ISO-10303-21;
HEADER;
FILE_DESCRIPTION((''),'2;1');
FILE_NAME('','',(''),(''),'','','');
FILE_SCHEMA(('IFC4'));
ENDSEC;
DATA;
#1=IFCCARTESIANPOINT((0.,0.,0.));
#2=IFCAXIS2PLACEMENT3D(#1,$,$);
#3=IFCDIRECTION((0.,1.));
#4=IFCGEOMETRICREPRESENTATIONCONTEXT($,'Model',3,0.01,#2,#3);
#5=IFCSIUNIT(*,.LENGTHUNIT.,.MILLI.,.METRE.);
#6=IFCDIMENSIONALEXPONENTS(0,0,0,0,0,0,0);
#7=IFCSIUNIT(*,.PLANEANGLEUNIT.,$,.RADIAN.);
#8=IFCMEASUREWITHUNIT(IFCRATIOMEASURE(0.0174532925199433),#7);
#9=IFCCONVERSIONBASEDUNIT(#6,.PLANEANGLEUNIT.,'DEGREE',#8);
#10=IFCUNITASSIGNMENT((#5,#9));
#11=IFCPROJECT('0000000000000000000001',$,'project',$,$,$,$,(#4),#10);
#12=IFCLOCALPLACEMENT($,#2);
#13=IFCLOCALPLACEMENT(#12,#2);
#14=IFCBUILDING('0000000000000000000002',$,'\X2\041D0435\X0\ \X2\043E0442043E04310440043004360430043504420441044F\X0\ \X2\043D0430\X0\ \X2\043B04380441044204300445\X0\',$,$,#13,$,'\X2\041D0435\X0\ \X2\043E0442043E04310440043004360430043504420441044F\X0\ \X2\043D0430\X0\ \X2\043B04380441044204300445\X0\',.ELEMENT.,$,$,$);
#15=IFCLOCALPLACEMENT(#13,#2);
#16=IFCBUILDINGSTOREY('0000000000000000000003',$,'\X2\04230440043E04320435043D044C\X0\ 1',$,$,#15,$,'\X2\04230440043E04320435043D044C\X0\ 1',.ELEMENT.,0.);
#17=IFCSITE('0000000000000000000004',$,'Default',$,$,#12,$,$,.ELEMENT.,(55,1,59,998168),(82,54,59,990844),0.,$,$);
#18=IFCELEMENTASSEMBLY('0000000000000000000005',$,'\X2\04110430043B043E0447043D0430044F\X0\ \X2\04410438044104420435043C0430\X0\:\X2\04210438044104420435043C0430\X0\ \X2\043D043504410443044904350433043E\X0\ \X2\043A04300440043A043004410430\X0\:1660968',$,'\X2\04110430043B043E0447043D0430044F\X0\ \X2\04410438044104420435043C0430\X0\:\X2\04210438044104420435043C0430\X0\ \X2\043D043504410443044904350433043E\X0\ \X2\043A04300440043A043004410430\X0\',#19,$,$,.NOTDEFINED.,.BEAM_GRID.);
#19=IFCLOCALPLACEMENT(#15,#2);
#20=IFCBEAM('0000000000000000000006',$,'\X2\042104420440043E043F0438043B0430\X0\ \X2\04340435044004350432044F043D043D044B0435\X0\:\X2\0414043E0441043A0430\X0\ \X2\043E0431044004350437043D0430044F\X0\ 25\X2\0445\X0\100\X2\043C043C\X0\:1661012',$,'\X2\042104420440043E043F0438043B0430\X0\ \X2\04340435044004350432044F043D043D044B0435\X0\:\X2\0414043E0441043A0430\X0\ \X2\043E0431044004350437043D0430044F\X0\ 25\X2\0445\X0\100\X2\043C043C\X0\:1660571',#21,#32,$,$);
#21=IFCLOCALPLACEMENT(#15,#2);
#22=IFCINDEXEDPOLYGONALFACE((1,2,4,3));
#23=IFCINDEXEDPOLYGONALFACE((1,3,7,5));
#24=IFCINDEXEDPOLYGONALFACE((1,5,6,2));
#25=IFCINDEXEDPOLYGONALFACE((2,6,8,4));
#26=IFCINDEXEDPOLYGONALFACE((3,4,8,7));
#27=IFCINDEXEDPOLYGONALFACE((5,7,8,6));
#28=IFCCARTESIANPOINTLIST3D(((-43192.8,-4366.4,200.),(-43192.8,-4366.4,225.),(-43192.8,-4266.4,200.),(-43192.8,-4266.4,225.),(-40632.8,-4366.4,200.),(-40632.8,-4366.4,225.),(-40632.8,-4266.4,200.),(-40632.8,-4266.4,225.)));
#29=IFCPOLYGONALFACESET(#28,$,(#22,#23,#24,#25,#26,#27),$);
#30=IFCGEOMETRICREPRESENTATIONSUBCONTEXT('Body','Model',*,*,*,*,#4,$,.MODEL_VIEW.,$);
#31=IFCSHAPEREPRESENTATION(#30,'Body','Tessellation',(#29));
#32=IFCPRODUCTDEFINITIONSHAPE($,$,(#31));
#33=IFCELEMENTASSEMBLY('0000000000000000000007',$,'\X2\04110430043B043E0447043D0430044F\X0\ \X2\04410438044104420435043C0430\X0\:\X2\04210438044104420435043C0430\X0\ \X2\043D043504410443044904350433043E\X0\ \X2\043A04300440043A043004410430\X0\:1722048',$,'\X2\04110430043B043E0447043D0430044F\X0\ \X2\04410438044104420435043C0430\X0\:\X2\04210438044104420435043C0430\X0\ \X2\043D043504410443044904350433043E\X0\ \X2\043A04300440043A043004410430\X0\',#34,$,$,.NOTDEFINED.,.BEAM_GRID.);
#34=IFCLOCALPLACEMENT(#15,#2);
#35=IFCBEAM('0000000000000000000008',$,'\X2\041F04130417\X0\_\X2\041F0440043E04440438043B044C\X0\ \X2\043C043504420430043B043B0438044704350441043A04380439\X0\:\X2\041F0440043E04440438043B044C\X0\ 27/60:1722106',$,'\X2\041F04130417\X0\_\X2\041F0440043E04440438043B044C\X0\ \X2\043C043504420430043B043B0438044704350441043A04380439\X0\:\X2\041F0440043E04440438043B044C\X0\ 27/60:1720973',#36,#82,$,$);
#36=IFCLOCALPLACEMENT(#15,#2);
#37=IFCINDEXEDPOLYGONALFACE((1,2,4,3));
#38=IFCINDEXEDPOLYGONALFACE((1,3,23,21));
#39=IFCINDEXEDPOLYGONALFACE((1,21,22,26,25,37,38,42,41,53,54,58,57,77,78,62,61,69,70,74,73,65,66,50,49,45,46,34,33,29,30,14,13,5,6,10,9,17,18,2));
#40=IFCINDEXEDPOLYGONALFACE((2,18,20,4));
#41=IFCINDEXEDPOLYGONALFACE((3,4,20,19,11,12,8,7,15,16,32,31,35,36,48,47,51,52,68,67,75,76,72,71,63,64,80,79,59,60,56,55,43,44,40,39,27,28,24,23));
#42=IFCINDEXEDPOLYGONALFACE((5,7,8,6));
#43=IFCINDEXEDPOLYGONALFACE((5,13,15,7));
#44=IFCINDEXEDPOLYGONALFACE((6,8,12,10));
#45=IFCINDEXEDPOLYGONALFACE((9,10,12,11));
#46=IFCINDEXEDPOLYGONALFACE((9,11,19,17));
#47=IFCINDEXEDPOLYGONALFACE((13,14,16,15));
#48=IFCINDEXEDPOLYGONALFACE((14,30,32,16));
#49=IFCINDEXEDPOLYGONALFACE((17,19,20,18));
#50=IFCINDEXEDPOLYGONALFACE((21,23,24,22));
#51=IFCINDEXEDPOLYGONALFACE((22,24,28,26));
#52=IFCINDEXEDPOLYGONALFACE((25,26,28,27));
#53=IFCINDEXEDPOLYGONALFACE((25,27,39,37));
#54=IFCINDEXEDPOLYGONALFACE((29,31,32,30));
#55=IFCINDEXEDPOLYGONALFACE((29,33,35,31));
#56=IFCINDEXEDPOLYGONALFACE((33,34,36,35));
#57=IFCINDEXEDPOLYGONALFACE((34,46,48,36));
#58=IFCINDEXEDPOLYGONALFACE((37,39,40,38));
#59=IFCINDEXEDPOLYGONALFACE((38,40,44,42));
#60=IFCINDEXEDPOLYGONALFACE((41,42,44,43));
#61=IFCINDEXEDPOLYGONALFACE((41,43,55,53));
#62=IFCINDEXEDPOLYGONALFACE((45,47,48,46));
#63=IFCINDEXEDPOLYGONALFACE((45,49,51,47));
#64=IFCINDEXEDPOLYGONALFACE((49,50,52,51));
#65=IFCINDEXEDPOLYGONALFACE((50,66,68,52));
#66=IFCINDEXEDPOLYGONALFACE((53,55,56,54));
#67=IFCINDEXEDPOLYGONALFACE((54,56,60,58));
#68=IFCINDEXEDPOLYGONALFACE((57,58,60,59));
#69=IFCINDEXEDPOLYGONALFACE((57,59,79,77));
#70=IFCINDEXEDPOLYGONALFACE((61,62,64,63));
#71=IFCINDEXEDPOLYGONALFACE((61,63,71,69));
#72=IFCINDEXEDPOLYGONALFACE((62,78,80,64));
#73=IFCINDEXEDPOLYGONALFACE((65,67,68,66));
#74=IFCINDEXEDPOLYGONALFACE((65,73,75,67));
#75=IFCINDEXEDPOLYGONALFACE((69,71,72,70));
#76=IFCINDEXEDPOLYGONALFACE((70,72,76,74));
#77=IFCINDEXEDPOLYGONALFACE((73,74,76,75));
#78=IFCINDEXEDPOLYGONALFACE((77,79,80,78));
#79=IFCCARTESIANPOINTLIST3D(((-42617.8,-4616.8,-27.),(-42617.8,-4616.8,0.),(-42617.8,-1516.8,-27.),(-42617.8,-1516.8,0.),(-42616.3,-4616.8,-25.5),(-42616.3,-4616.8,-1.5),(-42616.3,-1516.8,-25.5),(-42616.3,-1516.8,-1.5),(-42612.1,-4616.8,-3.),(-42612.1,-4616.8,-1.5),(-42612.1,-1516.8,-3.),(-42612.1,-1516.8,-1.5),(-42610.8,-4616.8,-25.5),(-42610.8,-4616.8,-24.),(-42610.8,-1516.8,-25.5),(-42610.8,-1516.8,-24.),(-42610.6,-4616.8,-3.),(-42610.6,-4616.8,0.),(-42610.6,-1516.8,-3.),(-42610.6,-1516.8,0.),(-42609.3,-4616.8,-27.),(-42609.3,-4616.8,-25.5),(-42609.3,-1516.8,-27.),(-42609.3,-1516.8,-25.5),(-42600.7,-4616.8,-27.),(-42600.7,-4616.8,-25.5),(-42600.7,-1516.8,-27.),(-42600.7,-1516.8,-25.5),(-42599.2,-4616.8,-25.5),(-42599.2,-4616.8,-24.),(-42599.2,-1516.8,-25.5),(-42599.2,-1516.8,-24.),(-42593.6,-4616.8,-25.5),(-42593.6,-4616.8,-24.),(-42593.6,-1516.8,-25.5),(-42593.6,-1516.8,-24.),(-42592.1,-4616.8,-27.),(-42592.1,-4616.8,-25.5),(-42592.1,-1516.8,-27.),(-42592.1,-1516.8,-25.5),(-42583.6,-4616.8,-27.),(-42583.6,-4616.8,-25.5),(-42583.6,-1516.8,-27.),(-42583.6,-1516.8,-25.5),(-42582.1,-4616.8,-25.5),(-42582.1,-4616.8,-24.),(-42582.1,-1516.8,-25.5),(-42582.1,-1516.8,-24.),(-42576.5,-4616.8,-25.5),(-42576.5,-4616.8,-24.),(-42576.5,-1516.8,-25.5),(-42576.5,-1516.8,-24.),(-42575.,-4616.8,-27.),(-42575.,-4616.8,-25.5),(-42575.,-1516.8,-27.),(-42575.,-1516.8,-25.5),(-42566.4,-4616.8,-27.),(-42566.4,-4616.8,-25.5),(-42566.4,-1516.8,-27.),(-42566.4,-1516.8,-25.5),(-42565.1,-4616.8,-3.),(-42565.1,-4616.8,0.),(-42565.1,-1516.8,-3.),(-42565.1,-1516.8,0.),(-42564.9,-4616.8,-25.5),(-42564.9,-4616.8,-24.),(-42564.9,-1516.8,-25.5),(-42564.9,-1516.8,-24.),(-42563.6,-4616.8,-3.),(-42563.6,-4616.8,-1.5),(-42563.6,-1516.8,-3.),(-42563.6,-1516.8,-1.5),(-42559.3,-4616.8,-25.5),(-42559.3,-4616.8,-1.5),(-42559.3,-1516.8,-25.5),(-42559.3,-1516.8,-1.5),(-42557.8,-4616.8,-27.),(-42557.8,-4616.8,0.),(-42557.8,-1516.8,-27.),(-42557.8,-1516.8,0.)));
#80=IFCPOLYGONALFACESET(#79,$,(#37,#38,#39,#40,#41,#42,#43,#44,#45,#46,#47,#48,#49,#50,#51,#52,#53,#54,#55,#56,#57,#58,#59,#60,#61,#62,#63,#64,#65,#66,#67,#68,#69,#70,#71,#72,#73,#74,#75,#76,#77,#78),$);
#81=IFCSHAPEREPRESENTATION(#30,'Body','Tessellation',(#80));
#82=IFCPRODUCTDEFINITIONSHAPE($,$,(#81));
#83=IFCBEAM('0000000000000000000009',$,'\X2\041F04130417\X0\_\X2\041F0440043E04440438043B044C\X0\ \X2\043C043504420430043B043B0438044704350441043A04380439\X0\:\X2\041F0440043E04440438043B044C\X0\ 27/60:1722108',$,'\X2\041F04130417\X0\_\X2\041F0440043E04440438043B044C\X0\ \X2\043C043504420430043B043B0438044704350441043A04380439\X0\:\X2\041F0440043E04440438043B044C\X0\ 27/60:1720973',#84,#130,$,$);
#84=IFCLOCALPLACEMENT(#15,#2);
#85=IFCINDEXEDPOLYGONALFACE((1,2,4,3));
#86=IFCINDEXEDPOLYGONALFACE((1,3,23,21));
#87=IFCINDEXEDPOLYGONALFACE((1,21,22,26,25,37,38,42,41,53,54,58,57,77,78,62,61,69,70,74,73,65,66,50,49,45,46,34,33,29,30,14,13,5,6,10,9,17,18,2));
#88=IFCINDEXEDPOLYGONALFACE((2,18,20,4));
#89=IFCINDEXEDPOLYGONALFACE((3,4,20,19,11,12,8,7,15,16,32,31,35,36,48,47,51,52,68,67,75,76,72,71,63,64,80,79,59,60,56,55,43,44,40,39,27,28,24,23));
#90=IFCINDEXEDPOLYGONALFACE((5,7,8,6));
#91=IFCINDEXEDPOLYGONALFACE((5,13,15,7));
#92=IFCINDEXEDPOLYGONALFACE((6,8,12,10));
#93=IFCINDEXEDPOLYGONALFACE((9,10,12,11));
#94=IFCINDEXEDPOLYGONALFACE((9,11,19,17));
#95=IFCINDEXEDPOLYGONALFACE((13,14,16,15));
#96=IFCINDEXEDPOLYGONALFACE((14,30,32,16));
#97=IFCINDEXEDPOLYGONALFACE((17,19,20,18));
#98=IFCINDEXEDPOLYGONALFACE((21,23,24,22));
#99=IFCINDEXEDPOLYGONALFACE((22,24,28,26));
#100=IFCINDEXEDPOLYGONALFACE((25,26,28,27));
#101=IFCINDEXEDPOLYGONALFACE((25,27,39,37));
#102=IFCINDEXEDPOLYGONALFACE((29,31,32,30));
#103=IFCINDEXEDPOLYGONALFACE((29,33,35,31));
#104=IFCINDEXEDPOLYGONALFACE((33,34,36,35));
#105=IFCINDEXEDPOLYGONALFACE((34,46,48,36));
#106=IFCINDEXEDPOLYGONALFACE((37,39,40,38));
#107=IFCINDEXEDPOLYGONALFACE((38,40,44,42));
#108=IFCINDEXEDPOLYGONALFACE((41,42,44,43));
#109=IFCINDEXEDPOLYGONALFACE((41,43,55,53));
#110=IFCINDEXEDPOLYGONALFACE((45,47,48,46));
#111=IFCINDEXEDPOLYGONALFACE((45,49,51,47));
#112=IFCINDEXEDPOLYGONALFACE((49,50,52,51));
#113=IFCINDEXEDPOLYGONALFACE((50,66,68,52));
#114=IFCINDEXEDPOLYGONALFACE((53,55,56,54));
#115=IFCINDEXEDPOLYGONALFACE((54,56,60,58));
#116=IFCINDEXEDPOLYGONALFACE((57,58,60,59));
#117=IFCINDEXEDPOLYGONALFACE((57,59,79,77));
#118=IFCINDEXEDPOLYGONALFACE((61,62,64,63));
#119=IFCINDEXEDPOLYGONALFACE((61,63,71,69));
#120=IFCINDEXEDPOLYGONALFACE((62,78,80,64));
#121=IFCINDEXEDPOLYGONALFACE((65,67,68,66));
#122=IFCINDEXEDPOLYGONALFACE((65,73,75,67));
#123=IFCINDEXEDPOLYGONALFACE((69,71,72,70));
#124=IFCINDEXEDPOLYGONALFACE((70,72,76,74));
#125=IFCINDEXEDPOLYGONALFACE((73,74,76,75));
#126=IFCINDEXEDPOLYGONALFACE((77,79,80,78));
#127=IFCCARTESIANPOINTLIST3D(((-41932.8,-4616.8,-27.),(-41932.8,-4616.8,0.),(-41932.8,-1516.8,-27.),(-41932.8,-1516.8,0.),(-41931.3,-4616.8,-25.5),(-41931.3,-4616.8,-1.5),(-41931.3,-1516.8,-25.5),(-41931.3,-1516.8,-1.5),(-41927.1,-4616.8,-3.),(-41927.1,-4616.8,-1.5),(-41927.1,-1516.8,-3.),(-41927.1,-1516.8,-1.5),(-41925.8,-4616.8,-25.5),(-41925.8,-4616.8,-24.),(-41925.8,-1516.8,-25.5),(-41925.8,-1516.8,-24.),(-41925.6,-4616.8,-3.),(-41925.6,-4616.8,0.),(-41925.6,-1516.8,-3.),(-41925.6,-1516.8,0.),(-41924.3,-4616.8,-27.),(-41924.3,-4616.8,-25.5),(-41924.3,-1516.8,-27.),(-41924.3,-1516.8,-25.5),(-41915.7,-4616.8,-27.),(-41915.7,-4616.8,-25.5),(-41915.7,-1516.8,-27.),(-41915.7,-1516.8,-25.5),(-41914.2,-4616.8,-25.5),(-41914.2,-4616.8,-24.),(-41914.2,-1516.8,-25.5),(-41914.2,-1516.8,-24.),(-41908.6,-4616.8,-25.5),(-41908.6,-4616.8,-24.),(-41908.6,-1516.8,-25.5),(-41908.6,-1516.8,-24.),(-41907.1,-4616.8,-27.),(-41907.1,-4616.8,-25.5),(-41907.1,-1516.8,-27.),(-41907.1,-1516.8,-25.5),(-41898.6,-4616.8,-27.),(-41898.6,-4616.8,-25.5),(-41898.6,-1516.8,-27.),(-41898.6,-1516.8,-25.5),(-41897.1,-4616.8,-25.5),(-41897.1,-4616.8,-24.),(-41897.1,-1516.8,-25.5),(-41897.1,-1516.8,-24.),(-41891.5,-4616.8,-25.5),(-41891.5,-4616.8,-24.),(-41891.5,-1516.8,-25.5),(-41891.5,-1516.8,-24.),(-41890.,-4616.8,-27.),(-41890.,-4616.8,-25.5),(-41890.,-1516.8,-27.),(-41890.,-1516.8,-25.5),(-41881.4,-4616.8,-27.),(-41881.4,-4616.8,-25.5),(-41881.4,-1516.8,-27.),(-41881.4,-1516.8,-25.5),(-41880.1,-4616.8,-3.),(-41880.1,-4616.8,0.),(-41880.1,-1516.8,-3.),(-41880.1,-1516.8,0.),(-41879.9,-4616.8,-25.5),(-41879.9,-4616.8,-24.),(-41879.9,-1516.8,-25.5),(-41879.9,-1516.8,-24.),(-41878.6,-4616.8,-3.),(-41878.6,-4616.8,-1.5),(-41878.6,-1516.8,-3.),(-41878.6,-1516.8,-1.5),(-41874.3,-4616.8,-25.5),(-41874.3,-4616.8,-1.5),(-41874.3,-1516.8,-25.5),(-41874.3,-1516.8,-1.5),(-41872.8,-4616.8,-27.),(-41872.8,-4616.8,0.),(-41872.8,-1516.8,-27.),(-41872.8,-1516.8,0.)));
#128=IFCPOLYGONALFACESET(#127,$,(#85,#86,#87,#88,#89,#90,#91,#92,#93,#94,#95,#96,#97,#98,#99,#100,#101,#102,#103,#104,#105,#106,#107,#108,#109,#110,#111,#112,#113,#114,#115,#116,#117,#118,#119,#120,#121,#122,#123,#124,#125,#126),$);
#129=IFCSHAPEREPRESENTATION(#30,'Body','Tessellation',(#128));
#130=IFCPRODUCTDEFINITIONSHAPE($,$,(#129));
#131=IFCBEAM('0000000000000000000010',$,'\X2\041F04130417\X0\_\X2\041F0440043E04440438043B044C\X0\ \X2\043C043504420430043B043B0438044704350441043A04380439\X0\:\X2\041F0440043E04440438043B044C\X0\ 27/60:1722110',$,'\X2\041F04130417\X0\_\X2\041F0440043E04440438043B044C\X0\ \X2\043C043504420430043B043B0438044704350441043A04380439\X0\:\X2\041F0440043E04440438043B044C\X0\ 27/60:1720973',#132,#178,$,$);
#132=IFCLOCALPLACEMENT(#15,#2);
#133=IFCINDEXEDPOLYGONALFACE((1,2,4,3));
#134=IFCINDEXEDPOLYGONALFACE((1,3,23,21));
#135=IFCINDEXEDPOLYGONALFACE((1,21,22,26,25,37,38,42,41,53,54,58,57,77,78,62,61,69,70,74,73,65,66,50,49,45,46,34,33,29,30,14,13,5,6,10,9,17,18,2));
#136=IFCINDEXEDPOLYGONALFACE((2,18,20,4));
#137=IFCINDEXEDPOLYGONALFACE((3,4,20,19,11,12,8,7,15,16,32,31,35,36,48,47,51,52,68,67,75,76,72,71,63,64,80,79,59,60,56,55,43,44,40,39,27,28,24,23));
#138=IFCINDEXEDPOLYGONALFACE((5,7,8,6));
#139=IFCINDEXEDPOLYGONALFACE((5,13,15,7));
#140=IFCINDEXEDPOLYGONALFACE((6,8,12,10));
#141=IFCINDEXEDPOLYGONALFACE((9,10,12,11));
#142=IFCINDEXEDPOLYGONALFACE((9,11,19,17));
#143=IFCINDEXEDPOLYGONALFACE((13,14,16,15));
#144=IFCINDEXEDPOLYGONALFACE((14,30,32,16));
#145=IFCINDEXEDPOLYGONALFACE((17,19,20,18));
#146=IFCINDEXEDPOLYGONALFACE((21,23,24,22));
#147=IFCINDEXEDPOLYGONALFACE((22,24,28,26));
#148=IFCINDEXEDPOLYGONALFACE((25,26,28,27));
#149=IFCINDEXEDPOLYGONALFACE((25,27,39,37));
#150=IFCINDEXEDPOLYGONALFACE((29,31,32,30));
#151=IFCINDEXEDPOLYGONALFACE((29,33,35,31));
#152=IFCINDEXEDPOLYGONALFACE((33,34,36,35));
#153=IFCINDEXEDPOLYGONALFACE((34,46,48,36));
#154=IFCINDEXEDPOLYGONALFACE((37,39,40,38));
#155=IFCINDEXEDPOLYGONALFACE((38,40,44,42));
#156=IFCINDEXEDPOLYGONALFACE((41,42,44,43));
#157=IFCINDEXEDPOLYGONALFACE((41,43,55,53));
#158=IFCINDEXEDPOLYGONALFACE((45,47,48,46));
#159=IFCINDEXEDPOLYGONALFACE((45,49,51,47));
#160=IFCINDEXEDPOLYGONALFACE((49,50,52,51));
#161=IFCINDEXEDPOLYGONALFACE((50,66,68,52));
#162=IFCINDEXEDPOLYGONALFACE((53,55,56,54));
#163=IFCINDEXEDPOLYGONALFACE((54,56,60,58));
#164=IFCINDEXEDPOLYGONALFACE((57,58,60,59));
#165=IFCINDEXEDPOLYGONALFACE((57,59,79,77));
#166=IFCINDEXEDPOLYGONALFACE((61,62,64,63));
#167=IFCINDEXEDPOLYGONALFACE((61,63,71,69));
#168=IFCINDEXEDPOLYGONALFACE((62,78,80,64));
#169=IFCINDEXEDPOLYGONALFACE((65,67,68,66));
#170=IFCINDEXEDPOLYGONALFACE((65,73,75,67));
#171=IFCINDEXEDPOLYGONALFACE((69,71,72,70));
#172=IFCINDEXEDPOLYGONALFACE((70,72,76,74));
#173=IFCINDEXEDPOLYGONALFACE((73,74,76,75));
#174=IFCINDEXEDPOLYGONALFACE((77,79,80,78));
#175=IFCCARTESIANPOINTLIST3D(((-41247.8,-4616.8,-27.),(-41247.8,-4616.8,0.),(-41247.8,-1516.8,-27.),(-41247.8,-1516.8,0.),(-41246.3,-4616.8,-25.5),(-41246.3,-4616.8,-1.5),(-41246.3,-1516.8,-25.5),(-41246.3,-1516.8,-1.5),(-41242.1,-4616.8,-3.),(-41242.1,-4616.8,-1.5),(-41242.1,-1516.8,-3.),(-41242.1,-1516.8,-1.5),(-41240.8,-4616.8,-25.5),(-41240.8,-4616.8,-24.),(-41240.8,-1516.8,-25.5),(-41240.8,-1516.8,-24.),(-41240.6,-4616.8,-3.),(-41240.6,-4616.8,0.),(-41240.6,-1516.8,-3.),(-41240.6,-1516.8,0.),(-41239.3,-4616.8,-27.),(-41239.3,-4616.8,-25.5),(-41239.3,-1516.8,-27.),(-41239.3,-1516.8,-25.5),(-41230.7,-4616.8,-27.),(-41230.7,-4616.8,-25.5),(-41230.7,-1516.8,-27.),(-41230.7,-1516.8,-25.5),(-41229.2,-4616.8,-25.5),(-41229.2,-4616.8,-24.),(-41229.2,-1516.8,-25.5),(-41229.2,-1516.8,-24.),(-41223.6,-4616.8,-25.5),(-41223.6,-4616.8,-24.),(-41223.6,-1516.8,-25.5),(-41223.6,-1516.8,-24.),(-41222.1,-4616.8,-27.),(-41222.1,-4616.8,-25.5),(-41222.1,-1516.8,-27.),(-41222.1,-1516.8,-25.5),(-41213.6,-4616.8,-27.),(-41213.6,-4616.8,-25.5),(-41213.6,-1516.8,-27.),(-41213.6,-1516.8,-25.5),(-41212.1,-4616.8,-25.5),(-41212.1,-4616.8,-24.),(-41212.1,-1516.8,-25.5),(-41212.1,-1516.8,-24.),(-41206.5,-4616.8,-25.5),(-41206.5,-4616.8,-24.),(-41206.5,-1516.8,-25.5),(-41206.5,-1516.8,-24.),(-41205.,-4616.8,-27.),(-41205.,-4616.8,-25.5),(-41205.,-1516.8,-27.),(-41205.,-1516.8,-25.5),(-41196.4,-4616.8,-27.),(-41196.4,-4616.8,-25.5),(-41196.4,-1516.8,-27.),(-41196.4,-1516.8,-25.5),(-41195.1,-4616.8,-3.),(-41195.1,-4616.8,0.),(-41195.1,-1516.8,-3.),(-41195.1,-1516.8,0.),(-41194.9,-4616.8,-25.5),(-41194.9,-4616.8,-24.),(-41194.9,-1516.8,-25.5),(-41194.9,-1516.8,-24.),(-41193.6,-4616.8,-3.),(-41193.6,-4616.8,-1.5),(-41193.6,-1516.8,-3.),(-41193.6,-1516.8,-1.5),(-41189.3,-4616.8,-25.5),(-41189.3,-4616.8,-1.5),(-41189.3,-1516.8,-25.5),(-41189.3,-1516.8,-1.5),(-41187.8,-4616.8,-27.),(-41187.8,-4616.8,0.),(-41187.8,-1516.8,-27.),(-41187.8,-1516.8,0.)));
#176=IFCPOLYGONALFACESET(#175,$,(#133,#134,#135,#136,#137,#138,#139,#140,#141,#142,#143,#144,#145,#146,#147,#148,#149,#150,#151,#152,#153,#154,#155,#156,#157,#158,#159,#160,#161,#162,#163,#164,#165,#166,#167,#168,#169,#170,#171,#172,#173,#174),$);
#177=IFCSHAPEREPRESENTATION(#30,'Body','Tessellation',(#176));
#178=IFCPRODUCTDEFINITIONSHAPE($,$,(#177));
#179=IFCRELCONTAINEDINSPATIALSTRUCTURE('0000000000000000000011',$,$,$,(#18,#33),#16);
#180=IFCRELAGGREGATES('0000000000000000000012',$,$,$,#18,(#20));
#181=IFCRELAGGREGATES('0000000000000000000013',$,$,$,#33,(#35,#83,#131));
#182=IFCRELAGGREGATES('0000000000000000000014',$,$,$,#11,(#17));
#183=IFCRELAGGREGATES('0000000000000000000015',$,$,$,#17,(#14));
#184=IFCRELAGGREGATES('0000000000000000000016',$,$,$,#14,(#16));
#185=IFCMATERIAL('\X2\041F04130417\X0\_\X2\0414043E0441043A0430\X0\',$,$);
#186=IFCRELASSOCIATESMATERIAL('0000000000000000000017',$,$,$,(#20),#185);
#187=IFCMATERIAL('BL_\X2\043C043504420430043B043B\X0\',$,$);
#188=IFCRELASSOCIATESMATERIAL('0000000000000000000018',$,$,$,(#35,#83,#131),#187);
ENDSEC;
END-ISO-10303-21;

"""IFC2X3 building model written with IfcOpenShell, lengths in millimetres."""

from ifc_helpers import new_model, entity, si_unit, converted_unit, direction, frame, origin, origin_2d_with_axis, place, context, subcontext, project, spatial, polyline, rectangle, outline, extrude, material, element, aggregate, save


model = new_model("IFC2X3")

# Units and contexts
model_context = context("Model", 3, precision=0.01, world=origin(), true_north=direction((0.0, 1.0)))
body_context = subcontext(model_context, "Body", "Model", "MODEL_VIEW")
ifc_project = project(units=[si_unit("LENGTHUNIT", "METRE", prefix="MILLI"), converted_unit("PLANEANGLEUNIT", "DEGREE", entity("IfcRatioMeasure", 0.0174532925199433), si_unit("PLANEANGLEUNIT", "RADIAN"), dimensions=[0, 0, 0, 0, 0, 0, 0])], contexts=[model_context])

# Site, building, storey
site_placement = place(None, origin())
site = spatial("IfcSite", under=ifc_project, at=site_placement, Name="Default", CompositionType="ELEMENT", RefLatitude=(55, 1, 59, 998168), RefLongitude=(82, 54, 59, 990844), RefElevation=0.0)
building_placement = place(site_placement, origin())
building = spatial("IfcBuilding", under=site, at=building_placement, Name="Не отображается на листах", LongName="Не отображается на листах", CompositionType="ELEMENT")
storey_placement = place(building_placement, frame((0.0, 0.0, 0.0)))
storey = spatial("IfcBuildingStorey", under=building, at=storey_placement, Name="Уровень 1", LongName="Уровень 1", CompositionType="ELEMENT", Elevation=0.0)

# Element assemblies, beams
ifc_material_1 = material(Name="ПГЗ_Доска")
assembly_1_placement = place(storey_placement, origin())
assembly_1 = element("IfcElementAssembly", 1, at=assembly_1_placement, inside=storey, Name="Балочная система:Система несущего каркаса:1660968", ObjectType="Балочная система:Система несущего каркаса", AssemblyPlace="NOTDEFINED", PredefinedType="BEAM_GRID")
beam_1_placement = place(assembly_1_placement, frame((-43192.8, -4316.4, 0.0)))
beam_1 = element("IfcBeam", 2, at=beam_1_placement, material=ifc_material_1, Name="Стропила деревянные:Доска обрезная 25х100мм:1661012", ObjectType="Стропила деревянные:Доска обрезная 25х100мм:1660571", context=body_context, shape_type="SweptSolid", body=[
    extrude(rectangle(XDim=25.0, YDim=100.0, at=origin_2d_with_axis()), frame((0.0, 0.0, 212.5), z_axis=(1.0, 0.0, 0.0), x_axis=(0.0, 0.0, -1.0)), (0.0, 0.0, 1.0), 2560.0),
])
aggregate(assembly_1, [beam_1])
assembly_2_placement = place(storey_placement, origin())
assembly_2 = element("IfcElementAssembly", 3, at=assembly_2_placement, inside=storey, Name="Балочная система:Система несущего каркаса:1722048", ObjectType="Балочная система:Система несущего каркаса", AssemblyPlace="NOTDEFINED", PredefinedType="BEAM_GRID")
ifc_material_2 = material(Name="BL_металл")
beam_2_placement = place(assembly_2_placement, frame((-42587.8, -4616.8, 0.0), z_axis=(0.0, 0.0, 1.0), x_axis=(0.0, 1.0, 0.0)))
beam_2 = element("IfcBeam", 4, at=beam_2_placement, material=ifc_material_2, Name="ПГЗ_Профиль металлический:Профиль 27/60:1722106", ObjectType="ПГЗ_Профиль металлический:Профиль 27/60:1720973", context=body_context, shape_type="SweptSolid", body=[
    extrude(outline(polyline([(-18.4, -30.0), (8.6, -30.0), (8.6, -21.4), (7.1, -21.4), (7.1, -12.9), (8.6, -12.9), (8.6, -4.3), (7.1, -4.3), (7.1, 4.3), (8.6, 4.3), (8.6, 12.9), (7.1, 12.9), (7.1, 21.4), (8.6, 21.4), (8.6, 30.0), (-18.4, 30.0), (-18.4, 22.7), (-15.4, 22.7), (-15.4, 24.2), (-16.9, 24.2), (-16.9, 28.5), (7.1, 28.5), (7.1, 22.9), (5.6, 22.9), (5.6, 11.4), (7.1, 11.4), (7.1, 5.8), (5.6, 5.8), (5.6, -5.8), (7.1, -5.8), (7.1, -11.4), (5.6, -11.4), (5.6, -22.9), (7.1, -22.9), (7.1, -28.5), (-16.9, -28.5), (-16.9, -24.2), (-15.4, -24.2), (-15.4, -22.7), (-18.4, -22.7), (-18.4, -30.0)])), frame((0.0, 0.0, -18.4), z_axis=(1.0, 0.0, 0.0), x_axis=(0.0, 0.0, -1.0)), (0.0, 0.0, 1.0), 3100.0),
])
beam_3_placement = place(assembly_2_placement, frame((-41902.8, -4616.8, 0.0), z_axis=(0.0, 0.0, 1.0), x_axis=(0.0, 1.0, 0.0)))
beam_3 = element("IfcBeam", 5, at=beam_3_placement, material=ifc_material_2, Name="ПГЗ_Профиль металлический:Профиль 27/60:1722108", ObjectType="ПГЗ_Профиль металлический:Профиль 27/60:1720973", context=body_context, shape_type="SweptSolid", body=[
    extrude(outline(polyline([(-18.4, -30.0), (8.6, -30.0), (8.6, -21.4), (7.1, -21.4), (7.1, -12.9), (8.6, -12.9), (8.6, -4.3), (7.1, -4.3), (7.1, 4.3), (8.6, 4.3), (8.6, 12.9), (7.1, 12.9), (7.1, 21.4), (8.6, 21.4), (8.6, 30.0), (-18.4, 30.0), (-18.4, 22.7), (-15.4, 22.7), (-15.4, 24.2), (-16.9, 24.2), (-16.9, 28.5), (7.1, 28.5), (7.1, 22.9), (5.6, 22.9), (5.6, 11.4), (7.1, 11.4), (7.1, 5.8), (5.6, 5.8), (5.6, -5.8), (7.1, -5.8), (7.1, -11.4), (5.6, -11.4), (5.6, -22.9), (7.1, -22.9), (7.1, -28.5), (-16.9, -28.5), (-16.9, -24.2), (-15.4, -24.2), (-15.4, -22.7), (-18.4, -22.7), (-18.4, -30.0)])), frame((0.0, 0.0, -18.4), z_axis=(1.0, 0.0, 0.0), x_axis=(0.0, 0.0, -1.0)), (0.0, 0.0, 1.0), 3100.0),
])
beam_4_placement = place(assembly_2_placement, frame((-41217.8, -4616.8, 0.0), z_axis=(0.0, 0.0, 1.0), x_axis=(0.0, 1.0, 0.0)))
beam_4 = element("IfcBeam", 6, at=beam_4_placement, material=ifc_material_2, Name="ПГЗ_Профиль металлический:Профиль 27/60:1722110", ObjectType="ПГЗ_Профиль металлический:Профиль 27/60:1720973", context=body_context, shape_type="SweptSolid", body=[
    extrude(outline(polyline([(-18.4, -30.0), (8.6, -30.0), (8.6, -21.4), (7.1, -21.4), (7.1, -12.9), (8.6, -12.9), (8.6, -4.3), (7.1, -4.3), (7.1, 4.3), (8.6, 4.3), (8.6, 12.9), (7.1, 12.9), (7.1, 21.4), (8.6, 21.4), (8.6, 30.0), (-18.4, 30.0), (-18.4, 22.7), (-15.4, 22.7), (-15.4, 24.2), (-16.9, 24.2), (-16.9, 28.5), (7.1, 28.5), (7.1, 22.9), (5.6, 22.9), (5.6, 11.4), (7.1, 11.4), (7.1, 5.8), (5.6, 5.8), (5.6, -5.8), (7.1, -5.8), (7.1, -11.4), (5.6, -11.4), (5.6, -22.9), (7.1, -22.9), (7.1, -28.5), (-16.9, -28.5), (-16.9, -24.2), (-15.4, -24.2), (-15.4, -22.7), (-18.4, -22.7), (-18.4, -30.0)])), frame((0.0, 0.0, -18.4), z_axis=(1.0, 0.0, 0.0), x_axis=(0.0, 0.0, -1.0)), (0.0, 0.0, 1.0), 3100.0),
])
aggregate(assembly_2, [beam_2, beam_3, beam_4])

save(model, "model.ifc")
